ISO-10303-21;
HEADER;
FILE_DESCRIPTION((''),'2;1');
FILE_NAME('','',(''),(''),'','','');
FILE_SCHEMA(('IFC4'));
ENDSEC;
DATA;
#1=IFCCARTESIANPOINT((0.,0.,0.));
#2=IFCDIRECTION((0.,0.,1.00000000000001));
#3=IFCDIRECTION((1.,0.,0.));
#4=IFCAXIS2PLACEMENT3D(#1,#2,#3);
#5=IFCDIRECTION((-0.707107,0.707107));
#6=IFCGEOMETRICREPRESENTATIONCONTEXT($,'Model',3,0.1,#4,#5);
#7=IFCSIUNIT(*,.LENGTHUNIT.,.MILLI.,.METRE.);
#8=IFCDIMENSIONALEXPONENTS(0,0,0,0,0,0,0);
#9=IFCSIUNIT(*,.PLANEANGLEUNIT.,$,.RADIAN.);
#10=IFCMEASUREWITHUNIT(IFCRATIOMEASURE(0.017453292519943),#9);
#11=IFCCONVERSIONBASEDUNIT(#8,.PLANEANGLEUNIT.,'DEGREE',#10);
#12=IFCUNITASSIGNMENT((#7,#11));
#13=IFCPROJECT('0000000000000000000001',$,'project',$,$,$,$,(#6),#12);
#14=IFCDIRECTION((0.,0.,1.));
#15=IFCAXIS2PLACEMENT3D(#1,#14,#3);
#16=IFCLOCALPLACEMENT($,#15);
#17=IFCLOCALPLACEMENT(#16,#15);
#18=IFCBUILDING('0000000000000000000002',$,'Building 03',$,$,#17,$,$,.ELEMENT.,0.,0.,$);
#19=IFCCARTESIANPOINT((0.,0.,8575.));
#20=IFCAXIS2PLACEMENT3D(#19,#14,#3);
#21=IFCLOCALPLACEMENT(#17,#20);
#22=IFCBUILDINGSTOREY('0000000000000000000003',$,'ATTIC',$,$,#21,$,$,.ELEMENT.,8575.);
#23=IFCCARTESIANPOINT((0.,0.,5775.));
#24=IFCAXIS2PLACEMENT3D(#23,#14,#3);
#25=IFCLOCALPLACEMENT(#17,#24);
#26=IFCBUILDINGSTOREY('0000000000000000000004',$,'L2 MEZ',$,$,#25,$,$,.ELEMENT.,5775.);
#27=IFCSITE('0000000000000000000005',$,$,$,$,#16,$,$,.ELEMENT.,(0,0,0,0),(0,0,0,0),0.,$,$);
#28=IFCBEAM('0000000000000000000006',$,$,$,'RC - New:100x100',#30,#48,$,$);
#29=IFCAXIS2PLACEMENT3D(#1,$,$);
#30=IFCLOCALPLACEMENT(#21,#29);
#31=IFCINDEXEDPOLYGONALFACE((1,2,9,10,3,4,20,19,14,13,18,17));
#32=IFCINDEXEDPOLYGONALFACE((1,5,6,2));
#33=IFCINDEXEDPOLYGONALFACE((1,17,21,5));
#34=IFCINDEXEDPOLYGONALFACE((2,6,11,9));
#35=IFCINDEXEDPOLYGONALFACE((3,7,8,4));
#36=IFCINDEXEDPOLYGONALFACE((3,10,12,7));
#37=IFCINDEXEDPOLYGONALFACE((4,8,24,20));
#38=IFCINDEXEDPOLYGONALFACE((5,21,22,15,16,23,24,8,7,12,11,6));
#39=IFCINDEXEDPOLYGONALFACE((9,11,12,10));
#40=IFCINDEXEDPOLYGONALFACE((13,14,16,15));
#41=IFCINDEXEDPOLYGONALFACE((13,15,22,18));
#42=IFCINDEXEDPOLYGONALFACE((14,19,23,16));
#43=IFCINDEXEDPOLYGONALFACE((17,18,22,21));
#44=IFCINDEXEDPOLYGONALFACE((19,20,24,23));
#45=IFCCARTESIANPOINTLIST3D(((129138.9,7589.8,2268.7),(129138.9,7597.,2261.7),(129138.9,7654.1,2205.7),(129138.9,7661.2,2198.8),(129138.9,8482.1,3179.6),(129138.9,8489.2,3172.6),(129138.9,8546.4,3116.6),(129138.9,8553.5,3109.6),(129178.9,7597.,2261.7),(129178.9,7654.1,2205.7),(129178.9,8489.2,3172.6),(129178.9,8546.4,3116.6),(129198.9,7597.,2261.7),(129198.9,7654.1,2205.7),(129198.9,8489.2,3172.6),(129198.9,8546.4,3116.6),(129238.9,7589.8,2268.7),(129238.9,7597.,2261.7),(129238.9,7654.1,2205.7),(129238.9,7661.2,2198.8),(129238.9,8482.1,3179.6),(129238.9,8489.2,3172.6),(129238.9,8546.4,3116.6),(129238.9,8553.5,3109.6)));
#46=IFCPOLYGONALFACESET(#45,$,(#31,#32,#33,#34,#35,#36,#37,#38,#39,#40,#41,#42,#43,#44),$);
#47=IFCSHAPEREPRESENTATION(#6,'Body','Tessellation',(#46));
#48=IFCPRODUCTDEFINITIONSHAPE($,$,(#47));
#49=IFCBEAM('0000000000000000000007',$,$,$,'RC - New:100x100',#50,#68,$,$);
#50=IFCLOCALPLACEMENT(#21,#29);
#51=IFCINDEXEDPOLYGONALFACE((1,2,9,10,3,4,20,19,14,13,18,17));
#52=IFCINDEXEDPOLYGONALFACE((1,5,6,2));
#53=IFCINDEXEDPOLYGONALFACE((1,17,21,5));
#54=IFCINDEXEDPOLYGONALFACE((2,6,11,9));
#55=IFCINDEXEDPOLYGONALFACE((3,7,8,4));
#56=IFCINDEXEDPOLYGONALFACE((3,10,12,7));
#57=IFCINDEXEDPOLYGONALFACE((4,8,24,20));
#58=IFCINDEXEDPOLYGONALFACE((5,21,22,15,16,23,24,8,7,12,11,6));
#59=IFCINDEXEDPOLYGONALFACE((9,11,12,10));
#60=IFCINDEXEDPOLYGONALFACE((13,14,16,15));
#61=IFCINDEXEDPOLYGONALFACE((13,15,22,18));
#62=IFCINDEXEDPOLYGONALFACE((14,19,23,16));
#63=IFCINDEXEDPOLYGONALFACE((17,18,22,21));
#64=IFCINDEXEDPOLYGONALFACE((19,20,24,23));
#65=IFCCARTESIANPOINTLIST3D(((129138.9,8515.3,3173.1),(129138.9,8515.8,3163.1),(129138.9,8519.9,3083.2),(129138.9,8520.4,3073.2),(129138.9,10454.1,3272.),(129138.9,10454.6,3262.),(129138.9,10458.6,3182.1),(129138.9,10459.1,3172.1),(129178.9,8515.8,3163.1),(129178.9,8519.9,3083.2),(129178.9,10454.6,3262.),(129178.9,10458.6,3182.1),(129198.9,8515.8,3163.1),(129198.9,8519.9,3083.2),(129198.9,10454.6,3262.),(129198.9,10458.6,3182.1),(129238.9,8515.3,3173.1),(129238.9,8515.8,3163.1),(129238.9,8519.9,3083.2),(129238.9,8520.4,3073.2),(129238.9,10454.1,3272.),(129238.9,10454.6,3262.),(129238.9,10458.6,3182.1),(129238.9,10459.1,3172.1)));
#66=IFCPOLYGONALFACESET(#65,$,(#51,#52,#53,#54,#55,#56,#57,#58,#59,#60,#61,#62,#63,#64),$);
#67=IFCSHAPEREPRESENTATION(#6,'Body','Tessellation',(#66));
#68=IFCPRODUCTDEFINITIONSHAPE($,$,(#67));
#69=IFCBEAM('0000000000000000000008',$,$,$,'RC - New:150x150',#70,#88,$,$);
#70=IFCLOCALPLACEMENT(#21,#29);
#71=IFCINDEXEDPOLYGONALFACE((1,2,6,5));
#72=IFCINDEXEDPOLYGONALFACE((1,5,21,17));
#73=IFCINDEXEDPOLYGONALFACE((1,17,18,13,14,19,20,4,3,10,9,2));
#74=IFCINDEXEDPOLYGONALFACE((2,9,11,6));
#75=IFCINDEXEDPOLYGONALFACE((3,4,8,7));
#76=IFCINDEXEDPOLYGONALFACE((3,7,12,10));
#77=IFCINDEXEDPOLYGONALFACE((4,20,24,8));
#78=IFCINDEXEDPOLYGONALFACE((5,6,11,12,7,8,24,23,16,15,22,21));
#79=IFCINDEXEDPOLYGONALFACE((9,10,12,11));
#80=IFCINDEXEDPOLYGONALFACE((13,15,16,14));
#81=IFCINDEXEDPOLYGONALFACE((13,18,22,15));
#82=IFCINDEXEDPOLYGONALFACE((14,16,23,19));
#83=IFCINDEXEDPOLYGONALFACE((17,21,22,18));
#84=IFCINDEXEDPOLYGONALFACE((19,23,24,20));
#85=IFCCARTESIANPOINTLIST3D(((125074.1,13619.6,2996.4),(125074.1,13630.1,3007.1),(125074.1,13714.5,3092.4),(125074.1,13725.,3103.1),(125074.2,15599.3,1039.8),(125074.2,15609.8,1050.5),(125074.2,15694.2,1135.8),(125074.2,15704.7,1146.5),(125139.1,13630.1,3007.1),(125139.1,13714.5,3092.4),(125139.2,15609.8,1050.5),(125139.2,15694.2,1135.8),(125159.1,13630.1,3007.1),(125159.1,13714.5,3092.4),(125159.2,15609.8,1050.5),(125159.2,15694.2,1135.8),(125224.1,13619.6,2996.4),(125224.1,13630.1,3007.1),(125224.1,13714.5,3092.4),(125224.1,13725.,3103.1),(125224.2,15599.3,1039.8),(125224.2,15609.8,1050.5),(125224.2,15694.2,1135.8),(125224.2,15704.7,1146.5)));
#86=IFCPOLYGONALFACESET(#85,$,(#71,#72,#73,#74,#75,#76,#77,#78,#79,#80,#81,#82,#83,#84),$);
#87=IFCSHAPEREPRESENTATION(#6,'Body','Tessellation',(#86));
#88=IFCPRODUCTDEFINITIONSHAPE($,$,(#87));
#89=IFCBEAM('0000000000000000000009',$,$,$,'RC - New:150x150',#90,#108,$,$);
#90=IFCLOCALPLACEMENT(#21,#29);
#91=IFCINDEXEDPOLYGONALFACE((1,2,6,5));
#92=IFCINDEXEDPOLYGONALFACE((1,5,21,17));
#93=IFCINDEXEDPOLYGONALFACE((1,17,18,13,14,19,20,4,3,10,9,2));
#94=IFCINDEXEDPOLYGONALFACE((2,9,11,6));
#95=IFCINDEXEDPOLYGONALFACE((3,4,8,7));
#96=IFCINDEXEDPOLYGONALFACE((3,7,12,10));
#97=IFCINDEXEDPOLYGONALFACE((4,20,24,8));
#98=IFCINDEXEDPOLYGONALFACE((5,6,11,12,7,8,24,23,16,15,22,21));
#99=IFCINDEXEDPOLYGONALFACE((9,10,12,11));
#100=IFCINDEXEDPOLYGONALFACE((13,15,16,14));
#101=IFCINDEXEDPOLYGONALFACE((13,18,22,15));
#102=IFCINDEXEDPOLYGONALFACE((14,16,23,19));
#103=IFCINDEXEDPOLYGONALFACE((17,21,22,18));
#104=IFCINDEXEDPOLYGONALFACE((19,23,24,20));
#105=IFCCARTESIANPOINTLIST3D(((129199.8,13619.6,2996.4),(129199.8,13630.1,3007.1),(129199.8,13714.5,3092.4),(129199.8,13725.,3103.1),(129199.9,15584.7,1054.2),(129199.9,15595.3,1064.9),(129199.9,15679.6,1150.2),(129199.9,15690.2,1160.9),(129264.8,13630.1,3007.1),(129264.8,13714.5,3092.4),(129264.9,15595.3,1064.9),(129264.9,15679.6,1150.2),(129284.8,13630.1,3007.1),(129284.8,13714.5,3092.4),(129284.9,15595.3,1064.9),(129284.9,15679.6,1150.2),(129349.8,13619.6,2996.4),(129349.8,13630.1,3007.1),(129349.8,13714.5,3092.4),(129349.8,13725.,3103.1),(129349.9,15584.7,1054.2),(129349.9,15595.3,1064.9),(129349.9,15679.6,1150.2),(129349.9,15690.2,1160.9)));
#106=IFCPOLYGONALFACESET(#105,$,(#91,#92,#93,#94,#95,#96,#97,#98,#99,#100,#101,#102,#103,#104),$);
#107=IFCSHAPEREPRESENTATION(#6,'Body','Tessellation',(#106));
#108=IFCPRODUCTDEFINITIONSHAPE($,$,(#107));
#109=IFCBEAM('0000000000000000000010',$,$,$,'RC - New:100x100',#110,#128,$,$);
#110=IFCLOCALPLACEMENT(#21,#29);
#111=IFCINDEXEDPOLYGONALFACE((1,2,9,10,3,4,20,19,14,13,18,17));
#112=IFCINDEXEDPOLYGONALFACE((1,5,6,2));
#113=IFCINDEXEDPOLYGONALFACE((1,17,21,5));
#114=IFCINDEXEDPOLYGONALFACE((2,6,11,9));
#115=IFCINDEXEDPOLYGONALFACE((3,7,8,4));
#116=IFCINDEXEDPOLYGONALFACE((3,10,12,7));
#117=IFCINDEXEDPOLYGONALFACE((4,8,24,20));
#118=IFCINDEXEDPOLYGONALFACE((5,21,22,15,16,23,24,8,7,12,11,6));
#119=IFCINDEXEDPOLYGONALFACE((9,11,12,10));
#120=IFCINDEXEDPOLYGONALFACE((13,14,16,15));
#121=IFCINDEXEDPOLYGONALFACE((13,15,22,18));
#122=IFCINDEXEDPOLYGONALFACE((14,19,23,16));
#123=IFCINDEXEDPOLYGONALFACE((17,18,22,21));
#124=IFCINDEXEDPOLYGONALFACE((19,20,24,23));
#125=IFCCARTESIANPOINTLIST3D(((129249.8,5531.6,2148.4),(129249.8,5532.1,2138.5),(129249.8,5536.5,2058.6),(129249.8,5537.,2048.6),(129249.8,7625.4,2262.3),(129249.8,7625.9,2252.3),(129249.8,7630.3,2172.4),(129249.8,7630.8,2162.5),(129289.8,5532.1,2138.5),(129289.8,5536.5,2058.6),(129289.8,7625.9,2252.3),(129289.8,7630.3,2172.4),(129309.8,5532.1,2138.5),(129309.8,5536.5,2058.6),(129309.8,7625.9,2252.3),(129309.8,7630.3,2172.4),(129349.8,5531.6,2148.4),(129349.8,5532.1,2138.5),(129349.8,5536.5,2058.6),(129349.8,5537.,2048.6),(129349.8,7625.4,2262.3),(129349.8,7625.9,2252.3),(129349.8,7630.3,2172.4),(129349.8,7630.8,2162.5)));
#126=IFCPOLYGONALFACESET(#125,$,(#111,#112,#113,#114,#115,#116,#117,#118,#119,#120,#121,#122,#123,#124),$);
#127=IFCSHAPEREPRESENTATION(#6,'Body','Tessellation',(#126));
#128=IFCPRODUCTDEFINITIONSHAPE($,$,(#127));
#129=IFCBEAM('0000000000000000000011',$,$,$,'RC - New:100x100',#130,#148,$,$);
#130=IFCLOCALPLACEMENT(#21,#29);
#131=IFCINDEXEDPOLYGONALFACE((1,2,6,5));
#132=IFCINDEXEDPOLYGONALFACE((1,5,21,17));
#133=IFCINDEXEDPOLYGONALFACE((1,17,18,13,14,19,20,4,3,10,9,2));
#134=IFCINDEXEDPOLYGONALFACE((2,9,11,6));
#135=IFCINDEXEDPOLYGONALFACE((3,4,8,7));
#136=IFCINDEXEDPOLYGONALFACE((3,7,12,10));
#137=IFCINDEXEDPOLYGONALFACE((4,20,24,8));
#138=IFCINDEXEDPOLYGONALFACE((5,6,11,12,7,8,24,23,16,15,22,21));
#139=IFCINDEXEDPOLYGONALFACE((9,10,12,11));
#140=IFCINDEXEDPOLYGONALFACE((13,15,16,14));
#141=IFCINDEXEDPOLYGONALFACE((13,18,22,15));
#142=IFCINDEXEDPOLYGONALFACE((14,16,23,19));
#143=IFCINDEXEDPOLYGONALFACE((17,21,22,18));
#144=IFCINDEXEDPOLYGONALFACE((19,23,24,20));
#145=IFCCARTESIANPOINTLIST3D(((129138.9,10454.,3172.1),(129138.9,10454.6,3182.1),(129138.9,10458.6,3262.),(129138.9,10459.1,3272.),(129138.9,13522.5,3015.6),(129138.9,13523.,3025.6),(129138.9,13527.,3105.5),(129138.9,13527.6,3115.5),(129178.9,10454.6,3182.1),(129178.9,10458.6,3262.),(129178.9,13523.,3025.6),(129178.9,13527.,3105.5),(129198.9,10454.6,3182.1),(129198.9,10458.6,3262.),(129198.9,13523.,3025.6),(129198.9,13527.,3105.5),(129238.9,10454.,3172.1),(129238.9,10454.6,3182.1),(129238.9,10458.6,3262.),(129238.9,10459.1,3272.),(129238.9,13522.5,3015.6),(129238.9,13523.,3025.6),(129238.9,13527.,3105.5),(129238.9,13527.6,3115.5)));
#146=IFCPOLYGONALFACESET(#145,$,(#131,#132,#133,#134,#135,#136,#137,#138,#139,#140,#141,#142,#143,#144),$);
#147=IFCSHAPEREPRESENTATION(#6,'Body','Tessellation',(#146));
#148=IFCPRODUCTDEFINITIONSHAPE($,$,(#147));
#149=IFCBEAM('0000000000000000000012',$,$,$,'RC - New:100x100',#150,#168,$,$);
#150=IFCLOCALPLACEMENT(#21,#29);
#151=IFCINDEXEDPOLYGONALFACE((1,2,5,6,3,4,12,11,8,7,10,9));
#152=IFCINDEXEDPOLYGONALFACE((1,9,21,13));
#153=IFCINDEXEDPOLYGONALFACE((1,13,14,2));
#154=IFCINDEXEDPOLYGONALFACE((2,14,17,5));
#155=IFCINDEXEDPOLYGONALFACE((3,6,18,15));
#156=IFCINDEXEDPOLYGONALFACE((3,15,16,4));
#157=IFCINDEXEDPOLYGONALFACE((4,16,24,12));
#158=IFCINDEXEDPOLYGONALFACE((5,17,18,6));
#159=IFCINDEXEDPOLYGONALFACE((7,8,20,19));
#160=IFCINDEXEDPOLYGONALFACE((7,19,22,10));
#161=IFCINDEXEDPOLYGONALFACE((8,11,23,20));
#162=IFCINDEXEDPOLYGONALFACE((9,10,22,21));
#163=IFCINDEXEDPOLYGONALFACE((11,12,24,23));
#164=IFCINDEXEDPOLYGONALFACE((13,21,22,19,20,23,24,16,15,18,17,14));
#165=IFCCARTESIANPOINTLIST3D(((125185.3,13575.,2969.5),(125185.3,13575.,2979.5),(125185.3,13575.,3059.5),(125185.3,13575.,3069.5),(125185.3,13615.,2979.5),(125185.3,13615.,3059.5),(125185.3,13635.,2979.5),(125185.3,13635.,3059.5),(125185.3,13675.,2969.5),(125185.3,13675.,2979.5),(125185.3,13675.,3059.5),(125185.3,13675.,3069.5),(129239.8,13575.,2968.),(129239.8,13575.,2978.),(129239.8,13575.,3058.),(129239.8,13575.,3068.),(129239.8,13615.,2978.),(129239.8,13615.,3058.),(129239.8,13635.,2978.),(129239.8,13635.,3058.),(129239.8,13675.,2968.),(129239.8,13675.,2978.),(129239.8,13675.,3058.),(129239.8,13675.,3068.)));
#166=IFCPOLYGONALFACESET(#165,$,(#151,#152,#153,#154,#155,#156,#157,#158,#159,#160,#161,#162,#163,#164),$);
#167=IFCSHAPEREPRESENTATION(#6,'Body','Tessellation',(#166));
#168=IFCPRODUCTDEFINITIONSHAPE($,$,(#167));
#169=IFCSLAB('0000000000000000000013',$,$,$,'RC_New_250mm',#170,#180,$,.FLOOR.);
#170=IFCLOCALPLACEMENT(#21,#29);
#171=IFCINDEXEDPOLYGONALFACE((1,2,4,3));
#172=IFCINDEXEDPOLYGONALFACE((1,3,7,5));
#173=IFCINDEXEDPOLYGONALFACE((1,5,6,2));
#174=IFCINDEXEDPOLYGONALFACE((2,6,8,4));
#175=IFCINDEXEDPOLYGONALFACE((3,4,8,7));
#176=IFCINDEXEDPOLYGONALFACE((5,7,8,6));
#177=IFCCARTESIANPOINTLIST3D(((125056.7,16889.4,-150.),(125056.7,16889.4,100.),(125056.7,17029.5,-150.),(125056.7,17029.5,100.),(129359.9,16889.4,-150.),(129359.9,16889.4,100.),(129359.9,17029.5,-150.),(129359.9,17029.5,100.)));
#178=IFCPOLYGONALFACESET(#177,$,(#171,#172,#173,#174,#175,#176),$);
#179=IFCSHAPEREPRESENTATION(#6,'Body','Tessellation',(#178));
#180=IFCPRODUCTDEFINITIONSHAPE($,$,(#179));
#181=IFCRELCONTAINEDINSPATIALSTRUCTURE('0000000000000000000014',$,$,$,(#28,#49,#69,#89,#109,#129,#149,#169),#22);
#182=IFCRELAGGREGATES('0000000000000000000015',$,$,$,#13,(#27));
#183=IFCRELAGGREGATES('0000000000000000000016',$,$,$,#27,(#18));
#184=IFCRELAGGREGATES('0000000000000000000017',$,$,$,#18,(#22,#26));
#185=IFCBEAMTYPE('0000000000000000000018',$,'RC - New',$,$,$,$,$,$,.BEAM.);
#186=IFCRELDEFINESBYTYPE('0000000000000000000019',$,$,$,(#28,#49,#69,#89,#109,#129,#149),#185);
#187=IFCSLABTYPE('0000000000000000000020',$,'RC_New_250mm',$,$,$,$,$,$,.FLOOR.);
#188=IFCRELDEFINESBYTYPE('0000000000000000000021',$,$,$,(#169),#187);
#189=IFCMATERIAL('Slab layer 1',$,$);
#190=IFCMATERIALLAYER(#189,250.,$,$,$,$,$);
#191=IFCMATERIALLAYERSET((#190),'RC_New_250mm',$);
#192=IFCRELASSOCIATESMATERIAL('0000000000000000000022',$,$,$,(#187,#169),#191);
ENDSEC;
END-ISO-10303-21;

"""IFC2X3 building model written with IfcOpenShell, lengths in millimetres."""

from ifc_helpers import new_model, entity, si_unit, converted_unit, direction, frame, origin_with_axes, origin_2d, place, context, project, spatial, polyline, i_section, outline, extrude, material, layer, layer_set, layer_usage, type_object, element, save


model = new_model("IFC2X3")

# Units and contexts
model_context = context("Model", 3, precision=0.1, world=frame((0.0, 0.0, 0.0), z_axis=(0.0, 0.0, 1.00000000000001), x_axis=(1.0, 0.0, 0.0)), true_north=direction((-0.707107, 0.707107)))
ifc_project = project(units=[si_unit("LENGTHUNIT", "METRE", prefix="MILLI"), converted_unit("PLANEANGLEUNIT", "DEGREE", entity("IfcRatioMeasure", 0.017453292519943), si_unit("PLANEANGLEUNIT", "RADIAN"), dimensions=[0, 0, 0, 0, 0, 0, 0])], contexts=[model_context])

# Site, building, storey
site_placement = place(None, origin_with_axes())
site = spatial("IfcSite", under=ifc_project, at=site_placement, CompositionType="ELEMENT", RefLatitude=(0, 0, 0, 0), RefLongitude=(0, 0, 0, 0), RefElevation=0.0)
building_placement = place(site_placement, origin_with_axes())
building = spatial("IfcBuilding", under=site, at=building_placement, Name="Building 03", CompositionType="ELEMENT", ElevationOfRefHeight=0.0, ElevationOfTerrain=0.0)
storey_1_placement = place(building_placement, frame((0.0, 0.0, 8575.0), z_axis=(0.0, 0.0, 1.0), x_axis=(1.0, 0.0, 0.0)))
storey_1 = spatial("IfcBuildingStorey", under=building, at=storey_1_placement, Name="ATTIC", CompositionType="ELEMENT", Elevation=8575.0)

# Beams
beam_type = type_object("IfcBeamType", Name="RC - New", PredefinedType="BEAM")
beam_1_placement = place(site_placement, frame((129188.9, 8517.8, 11719.6), z_axis=(0.0, -0.6998, -0.714339), x_axis=(1.0, 0.0, 0.0)))
element("IfcBeam", 1, at=beam_1_placement, inside=storey_1, type_object=beam_type, ObjectType="RC - New:100x100", context=model_context, shape_type="SweptSolid", body=[
    extrude(outline(polyline([(-50.0, 50.0), (50.0, 50.0), (50.0, 40.0), (10.0, 40.0), (10.0, -40.0), (50.0, -40.0), (50.0, -50.0), (-50.0, -50.0), (-50.0, -40.0), (-10.0, -40.0), (-10.0, 40.0), (-50.0, 40.0), (-50.0, 50.0)])), frame((0.0, 0.0, 0.0), z_axis=(0.0, 0.0, 1.0), x_axis=(-1.0, 0.0, 0.0)), (0.0, 0.0, 1.0), 1275.1),
])
beam_2_placement = place(site_placement, frame((129188.9, 10456.6, 11797.0), z_axis=(0.0, -0.998703, -0.05092), x_axis=(1.0, 0.0, 0.0)))
element("IfcBeam", 2, at=beam_2_placement, inside=storey_1, type_object=beam_type, ObjectType="RC - New:100x100", context=model_context, shape_type="SweptSolid", body=[
    extrude(outline(polyline([(-50.0, 50.0), (50.0, 50.0), (50.0, 40.0), (10.0, 40.0), (10.0, -40.0), (50.0, -40.0), (50.0, -50.0), (-50.0, -50.0), (-50.0, -40.0), (-10.0, -40.0), (-10.0, 40.0), (-50.0, 40.0), (-50.0, 50.0)])), frame((0.0, 0.0, 0.0), z_axis=(0.0, 0.0, 1.0), x_axis=(-1.0, 0.0, 0.0)), (0.0, 0.0, 1.0), 1941.3),
])
beam_3_placement = place(site_placement, frame((125224.1, 13725.0, 11678.1), z_axis=(0.000039, 0.711247, -0.702942), x_axis=(-1.0, 0.000055, 0.0)))
element("IfcBeam", 3, at=beam_3_placement, inside=storey_1, type_object=beam_type, ObjectType="RC - New:150x150", context=model_context, shape_type="SweptSolid", body=[
    extrude(i_section(OverallWidth=150.0, OverallDepth=150.0, WebThickness=20.0, FlangeThickness=15.0, at=origin_2d()), frame((75.0, -75.0, 0.0), z_axis=(0.0, 0.0, 1.0), x_axis=(1.0, 0.0, 0.0)), (0.0, 0.0, 1.0), 2783.4),
])
beam_4_placement = place(site_placement, frame((129349.8, 13725.0, 11678.1), z_axis=(0.000039, 0.711247, -0.702942), x_axis=(-1.0, 0.000055, 0.0)))
element("IfcBeam", 4, at=beam_4_placement, inside=storey_1, type_object=beam_type, ObjectType="RC - New:150x150", context=model_context, shape_type="SweptSolid", body=[
    extrude(i_section(OverallWidth=150.0, OverallDepth=150.0, WebThickness=20.0, FlangeThickness=15.0, at=origin_2d()), frame((75.0, -75.0, 0.0), z_axis=(0.0, 0.0, 1.0), x_axis=(1.0, 0.0, 0.0)), (0.0, 0.0, 1.0), 2763.0),
])
beam_5_placement = place(site_placement, frame((129299.8, 5534.3, 10673.5), z_axis=(0.0, 0.998524, 0.054305), x_axis=(-1.0, 0.0, 0.0)))
element("IfcBeam", 5, at=beam_5_placement, inside=storey_1, type_object=beam_type, ObjectType="RC - New:100x100", context=model_context, shape_type="SweptSolid", body=[
    extrude(outline(polyline([(-50.0, 50.0), (50.0, 50.0), (50.0, 40.0), (10.0, 40.0), (10.0, -40.0), (50.0, -40.0), (50.0, -50.0), (-50.0, -50.0), (-50.0, -40.0), (-10.0, -40.0), (-10.0, 40.0), (-50.0, 40.0), (-50.0, 50.0)])), frame((0.0, 0.0, 0.0), z_axis=(0.0, 0.0, 1.0), x_axis=(-1.0, 0.0, 0.0)), (0.0, 0.0, 1.0), 2096.9),
])
beam_6_placement = place(site_placement, frame((129188.9, 10456.6, 11797.0), z_axis=(0.0, 0.998703, -0.05092), x_axis=(-1.0, 0.0, 0.0)))
element("IfcBeam", 6, at=beam_6_placement, inside=storey_1, type_object=beam_type, ObjectType="RC - New:100x100", context=model_context, shape_type="SweptSolid", body=[
    extrude(i_section(OverallWidth=100.0, OverallDepth=100.0, WebThickness=20.0, FlangeThickness=10.0, at=origin_2d()), origin_with_axes(), (0.0, 0.0, 1.0), 3072.4),
])
beam_7_placement = place(site_placement, frame((125185.3, 13625.0, 11594.5), z_axis=(1.0, 0.0, -0.00035), x_axis=(0.0, 1.0, 0.0)))
element("IfcBeam", 7, at=beam_7_placement, inside=storey_1, type_object=beam_type, ObjectType="RC - New:100x100", context=model_context, shape_type="SweptSolid", body=[
    extrude(i_section(OverallWidth=100.0, OverallDepth=100.0, WebThickness=20.0, FlangeThickness=10.0, at=origin_2d()), origin_with_axes(), (0.0, 0.0, 1.0), 4054.5),
])

# Slab
ifc_material_1 = material(Name="Slab layer 1")
ifc_layer_1 = layer(ifc_material_1, 250.0)
ifc_layer_set_1 = layer_set([ifc_layer_1], Name="RC_New_250mm")
ifc_layer_usage_1 = layer_usage(ifc_layer_set_1, "AXIS3", "POSITIVE", 0.0)
slab_type_1 = type_object("IfcSlabType", Name="RC_New_250mm", PredefinedType="FLOOR", material=ifc_layer_set_1)
slab_1_placement = place(site_placement, frame((125056.7, 16889.4, 8425.0), z_axis=(0.0, 0.0, 1.0), x_axis=(1.0, 0.0, 0.0)))
element("IfcSlab", 8, at=slab_1_placement, inside=storey_1, type_object=slab_type_1, material=ifc_layer_usage_1, ObjectType="RC_New_250mm", PredefinedType="FLOOR", context=model_context, shape_type="SweptSolid", body=[
    extrude(outline(polyline([(0.0, 0.0), (4303.2, 0.0), (4303.2, 140.1), (0.0, 140.1), (0.0, 0.0)])), origin_with_axes(), (0.0, 0.0, 1.0), 250.0),
])

# Shared definitions
storey_2_placement = place(building_placement, frame((0.0, 0.0, 5775.0), z_axis=(0.0, 0.0, 1.0), x_axis=(1.0, 0.0, 0.0)))
storey_2 = spatial("IfcBuildingStorey", under=building, at=storey_2_placement, Name="L2 MEZ", CompositionType="ELEMENT", Elevation=5775.0)

save(model, "model.ifc")
